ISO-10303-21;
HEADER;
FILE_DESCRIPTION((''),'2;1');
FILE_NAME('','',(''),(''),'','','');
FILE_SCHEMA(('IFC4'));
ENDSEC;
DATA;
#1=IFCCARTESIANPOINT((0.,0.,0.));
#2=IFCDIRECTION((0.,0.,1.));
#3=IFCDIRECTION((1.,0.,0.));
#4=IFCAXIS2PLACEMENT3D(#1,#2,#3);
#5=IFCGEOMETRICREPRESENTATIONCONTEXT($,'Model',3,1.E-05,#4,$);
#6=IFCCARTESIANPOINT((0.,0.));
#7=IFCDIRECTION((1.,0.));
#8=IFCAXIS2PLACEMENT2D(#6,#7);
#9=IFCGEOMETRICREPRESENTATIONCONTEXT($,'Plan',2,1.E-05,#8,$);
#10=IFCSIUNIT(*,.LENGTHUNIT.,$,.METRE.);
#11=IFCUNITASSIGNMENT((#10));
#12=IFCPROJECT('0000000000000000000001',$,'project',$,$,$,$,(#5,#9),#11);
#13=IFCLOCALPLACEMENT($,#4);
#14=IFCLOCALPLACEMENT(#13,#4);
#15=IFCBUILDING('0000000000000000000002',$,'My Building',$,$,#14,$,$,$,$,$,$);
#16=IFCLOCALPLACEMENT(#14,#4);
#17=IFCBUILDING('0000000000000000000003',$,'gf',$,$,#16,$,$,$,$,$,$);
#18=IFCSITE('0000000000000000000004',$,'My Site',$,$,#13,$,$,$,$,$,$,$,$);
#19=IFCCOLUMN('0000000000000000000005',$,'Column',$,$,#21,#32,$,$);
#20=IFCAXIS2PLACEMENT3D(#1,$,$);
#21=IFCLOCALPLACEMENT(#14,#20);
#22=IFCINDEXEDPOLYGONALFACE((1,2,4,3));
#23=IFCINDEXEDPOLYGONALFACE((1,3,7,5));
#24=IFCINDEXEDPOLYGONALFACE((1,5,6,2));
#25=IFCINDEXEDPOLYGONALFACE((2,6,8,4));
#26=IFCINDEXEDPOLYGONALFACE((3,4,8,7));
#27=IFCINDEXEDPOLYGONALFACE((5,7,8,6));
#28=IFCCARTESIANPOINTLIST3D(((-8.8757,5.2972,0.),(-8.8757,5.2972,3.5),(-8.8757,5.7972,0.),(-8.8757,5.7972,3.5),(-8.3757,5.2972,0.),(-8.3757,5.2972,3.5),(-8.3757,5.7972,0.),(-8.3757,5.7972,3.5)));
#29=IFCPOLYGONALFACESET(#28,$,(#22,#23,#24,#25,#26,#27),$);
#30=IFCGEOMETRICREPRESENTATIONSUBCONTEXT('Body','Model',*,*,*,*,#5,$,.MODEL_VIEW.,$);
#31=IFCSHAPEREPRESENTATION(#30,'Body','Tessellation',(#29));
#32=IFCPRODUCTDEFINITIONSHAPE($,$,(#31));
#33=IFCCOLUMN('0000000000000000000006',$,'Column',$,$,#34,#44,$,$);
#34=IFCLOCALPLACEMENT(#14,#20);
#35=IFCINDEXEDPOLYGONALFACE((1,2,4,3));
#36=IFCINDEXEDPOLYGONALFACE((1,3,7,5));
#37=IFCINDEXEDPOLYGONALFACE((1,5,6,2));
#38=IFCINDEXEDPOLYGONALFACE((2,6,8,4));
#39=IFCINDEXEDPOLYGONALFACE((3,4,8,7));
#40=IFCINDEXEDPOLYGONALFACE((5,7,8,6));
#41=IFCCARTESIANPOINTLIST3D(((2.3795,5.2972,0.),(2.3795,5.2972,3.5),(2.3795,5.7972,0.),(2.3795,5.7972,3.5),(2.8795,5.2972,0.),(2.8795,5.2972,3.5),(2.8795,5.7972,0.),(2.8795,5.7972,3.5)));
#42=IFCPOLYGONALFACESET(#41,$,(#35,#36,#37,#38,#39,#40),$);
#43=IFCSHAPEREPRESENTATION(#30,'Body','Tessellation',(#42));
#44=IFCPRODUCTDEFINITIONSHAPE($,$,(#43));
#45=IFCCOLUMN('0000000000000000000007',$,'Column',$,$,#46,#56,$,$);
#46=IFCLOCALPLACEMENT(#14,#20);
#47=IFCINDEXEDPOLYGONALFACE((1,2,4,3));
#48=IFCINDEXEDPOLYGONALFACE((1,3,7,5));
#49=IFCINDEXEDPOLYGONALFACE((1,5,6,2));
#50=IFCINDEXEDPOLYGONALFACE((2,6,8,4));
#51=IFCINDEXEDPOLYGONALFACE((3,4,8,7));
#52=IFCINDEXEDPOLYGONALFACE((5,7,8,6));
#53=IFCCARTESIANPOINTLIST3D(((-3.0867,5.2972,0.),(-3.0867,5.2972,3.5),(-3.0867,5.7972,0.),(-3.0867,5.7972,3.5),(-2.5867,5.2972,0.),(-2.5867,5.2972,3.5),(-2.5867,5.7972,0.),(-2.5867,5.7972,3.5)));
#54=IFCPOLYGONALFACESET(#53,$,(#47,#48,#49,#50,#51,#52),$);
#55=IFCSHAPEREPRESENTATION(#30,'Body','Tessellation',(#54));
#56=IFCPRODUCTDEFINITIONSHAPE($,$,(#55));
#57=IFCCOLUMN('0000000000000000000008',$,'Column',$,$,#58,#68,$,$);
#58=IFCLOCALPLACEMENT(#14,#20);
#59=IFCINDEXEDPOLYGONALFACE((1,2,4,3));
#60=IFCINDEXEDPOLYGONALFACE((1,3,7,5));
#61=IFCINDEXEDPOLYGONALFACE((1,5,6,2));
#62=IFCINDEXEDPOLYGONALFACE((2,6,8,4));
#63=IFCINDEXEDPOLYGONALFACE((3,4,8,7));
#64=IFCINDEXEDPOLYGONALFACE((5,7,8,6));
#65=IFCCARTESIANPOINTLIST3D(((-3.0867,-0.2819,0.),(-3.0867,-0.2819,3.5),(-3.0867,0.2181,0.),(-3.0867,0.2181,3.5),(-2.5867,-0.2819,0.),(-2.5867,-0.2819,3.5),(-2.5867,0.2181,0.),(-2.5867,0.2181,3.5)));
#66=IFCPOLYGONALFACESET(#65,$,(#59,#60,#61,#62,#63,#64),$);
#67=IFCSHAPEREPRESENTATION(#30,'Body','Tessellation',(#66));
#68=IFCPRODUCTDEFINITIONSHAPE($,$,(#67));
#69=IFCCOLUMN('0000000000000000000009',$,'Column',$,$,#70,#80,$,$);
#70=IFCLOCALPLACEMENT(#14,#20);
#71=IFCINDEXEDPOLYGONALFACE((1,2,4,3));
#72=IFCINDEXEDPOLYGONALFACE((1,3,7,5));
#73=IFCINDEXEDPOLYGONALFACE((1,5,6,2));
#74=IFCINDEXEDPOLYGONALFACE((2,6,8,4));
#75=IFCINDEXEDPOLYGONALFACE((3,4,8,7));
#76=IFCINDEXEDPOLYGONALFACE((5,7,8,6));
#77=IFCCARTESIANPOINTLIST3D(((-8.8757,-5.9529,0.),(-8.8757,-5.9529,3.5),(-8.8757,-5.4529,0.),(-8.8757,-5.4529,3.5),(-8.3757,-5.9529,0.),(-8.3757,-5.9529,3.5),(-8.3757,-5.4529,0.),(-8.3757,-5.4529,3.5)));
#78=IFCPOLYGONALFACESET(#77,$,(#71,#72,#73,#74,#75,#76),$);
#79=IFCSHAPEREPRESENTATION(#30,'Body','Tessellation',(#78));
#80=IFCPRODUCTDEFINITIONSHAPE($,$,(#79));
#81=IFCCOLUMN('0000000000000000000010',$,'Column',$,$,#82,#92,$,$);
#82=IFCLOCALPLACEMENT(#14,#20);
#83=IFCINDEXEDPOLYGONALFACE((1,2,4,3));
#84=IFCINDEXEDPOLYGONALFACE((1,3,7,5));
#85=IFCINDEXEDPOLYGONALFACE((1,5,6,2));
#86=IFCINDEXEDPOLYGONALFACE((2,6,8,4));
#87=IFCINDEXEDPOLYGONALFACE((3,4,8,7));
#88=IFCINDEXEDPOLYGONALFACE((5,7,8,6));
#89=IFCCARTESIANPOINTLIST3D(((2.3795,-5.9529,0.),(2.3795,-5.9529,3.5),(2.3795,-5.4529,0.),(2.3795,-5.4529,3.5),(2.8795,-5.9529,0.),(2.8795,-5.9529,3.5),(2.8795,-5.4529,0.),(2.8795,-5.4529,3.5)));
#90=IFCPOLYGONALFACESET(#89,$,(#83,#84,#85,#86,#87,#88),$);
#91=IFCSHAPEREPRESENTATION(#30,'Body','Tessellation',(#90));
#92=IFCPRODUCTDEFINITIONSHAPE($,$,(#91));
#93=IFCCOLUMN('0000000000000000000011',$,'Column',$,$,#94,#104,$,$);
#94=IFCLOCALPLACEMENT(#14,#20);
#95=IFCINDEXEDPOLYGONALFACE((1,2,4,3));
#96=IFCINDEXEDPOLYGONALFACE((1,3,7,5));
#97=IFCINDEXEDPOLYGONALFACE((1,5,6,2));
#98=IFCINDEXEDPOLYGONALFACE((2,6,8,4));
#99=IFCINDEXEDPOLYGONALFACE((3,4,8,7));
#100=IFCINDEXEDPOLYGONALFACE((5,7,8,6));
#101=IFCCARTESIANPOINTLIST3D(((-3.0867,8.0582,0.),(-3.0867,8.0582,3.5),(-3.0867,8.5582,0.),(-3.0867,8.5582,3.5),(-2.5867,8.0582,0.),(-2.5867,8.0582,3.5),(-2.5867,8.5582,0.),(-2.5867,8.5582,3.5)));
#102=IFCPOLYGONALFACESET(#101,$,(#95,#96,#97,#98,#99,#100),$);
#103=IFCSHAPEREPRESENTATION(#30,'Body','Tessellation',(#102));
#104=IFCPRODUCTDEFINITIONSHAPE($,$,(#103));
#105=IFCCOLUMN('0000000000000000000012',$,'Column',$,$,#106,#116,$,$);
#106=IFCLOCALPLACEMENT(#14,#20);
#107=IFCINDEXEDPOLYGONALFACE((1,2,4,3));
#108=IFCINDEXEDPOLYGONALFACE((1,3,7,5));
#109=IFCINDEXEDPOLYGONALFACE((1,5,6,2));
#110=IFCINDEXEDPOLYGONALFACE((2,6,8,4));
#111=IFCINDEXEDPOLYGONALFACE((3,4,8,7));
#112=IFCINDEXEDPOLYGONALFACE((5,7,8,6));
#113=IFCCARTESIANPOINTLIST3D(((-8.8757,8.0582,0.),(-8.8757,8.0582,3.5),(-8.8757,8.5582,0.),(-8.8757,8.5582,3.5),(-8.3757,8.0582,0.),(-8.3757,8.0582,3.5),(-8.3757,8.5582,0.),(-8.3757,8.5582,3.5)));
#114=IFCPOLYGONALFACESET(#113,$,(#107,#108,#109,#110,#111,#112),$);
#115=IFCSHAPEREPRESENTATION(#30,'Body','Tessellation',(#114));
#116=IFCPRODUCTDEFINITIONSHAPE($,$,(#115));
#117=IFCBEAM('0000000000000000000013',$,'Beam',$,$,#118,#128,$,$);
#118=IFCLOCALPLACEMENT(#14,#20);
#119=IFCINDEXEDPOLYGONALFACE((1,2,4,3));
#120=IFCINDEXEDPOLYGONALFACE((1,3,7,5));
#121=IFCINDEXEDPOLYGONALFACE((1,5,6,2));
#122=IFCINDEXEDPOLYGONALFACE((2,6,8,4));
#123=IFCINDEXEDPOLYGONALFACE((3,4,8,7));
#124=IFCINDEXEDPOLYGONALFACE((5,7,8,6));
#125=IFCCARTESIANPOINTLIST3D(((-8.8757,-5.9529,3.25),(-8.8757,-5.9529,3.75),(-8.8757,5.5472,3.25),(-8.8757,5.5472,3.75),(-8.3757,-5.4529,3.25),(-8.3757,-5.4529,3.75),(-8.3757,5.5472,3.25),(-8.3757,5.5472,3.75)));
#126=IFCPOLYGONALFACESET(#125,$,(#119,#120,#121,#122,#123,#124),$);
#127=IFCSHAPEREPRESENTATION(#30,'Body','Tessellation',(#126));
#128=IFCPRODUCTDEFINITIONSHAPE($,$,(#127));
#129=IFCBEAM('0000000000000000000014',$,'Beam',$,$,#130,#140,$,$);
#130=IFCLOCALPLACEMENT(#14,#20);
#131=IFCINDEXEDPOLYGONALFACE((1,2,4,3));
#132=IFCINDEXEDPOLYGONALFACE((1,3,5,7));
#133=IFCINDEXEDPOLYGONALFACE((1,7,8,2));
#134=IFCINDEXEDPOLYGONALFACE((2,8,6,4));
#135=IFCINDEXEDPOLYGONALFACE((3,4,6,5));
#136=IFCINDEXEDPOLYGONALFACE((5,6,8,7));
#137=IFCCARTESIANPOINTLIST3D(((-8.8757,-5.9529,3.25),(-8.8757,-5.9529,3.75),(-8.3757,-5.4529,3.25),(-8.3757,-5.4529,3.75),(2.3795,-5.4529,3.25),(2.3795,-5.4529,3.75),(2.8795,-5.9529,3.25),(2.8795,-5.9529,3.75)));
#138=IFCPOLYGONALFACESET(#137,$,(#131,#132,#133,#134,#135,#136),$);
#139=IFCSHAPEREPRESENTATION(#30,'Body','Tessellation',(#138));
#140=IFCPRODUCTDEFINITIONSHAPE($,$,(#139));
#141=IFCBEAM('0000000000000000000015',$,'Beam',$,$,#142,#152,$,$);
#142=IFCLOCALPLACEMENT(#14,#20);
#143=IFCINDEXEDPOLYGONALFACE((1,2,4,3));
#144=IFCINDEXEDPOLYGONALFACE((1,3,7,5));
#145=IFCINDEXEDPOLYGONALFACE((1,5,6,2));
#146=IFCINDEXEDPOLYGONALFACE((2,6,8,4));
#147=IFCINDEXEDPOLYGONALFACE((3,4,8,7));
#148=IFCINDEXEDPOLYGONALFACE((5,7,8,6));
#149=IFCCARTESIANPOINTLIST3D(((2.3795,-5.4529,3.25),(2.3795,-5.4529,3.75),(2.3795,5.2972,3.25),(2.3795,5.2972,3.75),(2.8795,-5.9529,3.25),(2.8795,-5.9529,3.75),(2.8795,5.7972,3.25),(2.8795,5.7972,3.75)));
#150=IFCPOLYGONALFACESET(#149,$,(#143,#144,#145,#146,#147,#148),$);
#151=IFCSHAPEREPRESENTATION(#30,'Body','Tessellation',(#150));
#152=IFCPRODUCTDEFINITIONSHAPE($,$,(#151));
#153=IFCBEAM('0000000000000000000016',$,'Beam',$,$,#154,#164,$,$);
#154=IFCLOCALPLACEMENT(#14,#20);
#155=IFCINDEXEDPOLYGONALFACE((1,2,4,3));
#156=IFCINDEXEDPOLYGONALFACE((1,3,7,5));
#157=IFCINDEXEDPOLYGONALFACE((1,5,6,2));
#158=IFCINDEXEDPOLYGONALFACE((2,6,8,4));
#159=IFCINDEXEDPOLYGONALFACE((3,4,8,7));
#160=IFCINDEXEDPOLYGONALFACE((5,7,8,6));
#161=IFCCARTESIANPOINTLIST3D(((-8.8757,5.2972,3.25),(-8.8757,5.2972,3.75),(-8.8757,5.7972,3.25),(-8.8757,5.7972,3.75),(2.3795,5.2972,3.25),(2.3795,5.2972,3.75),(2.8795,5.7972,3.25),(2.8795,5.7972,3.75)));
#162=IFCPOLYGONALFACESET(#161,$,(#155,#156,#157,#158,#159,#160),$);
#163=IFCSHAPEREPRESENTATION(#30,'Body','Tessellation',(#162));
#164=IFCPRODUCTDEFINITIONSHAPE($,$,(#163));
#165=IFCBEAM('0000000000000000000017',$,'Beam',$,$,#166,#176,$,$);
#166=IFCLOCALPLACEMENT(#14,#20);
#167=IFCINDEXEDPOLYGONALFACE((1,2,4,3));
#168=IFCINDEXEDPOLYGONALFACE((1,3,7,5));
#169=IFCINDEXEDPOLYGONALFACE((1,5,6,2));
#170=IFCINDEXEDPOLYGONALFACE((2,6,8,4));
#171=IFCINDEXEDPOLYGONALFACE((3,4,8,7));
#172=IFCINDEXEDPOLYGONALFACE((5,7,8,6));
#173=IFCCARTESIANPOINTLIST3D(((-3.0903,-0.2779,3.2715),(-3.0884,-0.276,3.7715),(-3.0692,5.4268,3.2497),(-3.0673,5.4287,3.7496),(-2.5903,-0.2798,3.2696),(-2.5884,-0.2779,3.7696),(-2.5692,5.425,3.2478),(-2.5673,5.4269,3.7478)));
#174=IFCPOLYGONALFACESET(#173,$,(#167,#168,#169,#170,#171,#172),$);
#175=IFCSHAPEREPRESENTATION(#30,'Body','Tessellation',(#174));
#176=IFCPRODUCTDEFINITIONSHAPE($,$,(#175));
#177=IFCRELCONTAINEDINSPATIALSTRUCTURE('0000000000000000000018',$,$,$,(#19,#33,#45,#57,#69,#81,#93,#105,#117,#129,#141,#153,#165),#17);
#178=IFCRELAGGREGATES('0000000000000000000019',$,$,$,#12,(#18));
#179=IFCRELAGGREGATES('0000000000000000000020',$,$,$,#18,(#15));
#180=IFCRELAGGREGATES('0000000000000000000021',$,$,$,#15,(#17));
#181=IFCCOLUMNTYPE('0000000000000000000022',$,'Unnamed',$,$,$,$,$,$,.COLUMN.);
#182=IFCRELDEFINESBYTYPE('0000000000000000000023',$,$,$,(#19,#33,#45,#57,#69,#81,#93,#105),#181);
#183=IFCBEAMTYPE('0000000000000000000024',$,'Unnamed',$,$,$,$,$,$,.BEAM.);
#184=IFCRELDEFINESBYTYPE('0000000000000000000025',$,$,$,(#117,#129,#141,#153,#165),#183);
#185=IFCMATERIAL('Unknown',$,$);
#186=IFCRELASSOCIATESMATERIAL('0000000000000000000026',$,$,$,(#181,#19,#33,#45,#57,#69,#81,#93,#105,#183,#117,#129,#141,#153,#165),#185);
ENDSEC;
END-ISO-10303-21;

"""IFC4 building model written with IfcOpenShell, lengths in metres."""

from ifc_helpers import new_model, si_unit, frame, origin_with_axes, origin_2d_with_axis, place, context, subcontext, project, spatial, rectangle, extrude, clip, halfspace, material, material_profile, profile_set, profile_usage, type_object, element, save


model = new_model("IFC4")

# Units and contexts
model_context = context("Model", 3, precision=1e-05, world=origin_with_axes())
plan_context = context("Plan", 2, precision=1e-05, world=origin_2d_with_axis())
body_context_1 = subcontext(model_context, "Body", "Model", "MODEL_VIEW")
ifc_project = project(units=[si_unit("LENGTHUNIT", "METRE")], contexts=[model_context, plan_context])

# Site, buildings
site_placement = place(None, origin_with_axes())
site = spatial("IfcSite", under=ifc_project, at=site_placement, Name="My Site")
building_1_placement = place(site_placement, origin_with_axes())
building_1 = spatial("IfcBuilding", under=site, at=building_1_placement, Name="My Building")
building_2_placement = place(building_1_placement, origin_with_axes())
building_2 = spatial("IfcBuilding", under=building_1, at=building_2_placement, Name="gf")

# Columns
ifc_material = material(Name="Unknown")
ifc_material_profile_1 = material_profile(ifc_material, rectangle(XDim=0.5, YDim=0.5))
ifc_profile_set_1 = profile_set([ifc_material_profile_1])
ifc_profile_usage_1 = profile_usage(ifc_profile_set_1, cardinal=5)
column_type = type_object("IfcColumnType", Name="Unnamed", PredefinedType="COLUMN", material=ifc_profile_set_1)
column_1_placement = place(building_2_placement, frame((-8.6257, 5.5472, 0.0), z_axis=(0.0, 0.0, 1.0), x_axis=(1.0, 0.0, 0.0)))
element("IfcColumn", 1, at=column_1_placement, inside=building_2, type_object=column_type, material=ifc_profile_usage_1, Name="Column", context=body_context_1, shape_type="SweptSolid", body=[
    extrude(rectangle(XDim=0.5, YDim=0.5), origin_with_axes(), (0.0, 0.0, 1.0), 3.5),
])
ifc_profile_usage_2 = profile_usage(ifc_profile_set_1, cardinal=5)
column_2_placement = place(building_2_placement, frame((2.6295, 5.5472, 0.0), z_axis=(0.0, 0.0, 1.0), x_axis=(1.0, 0.0, 0.0)))
element("IfcColumn", 2, at=column_2_placement, inside=building_2, type_object=column_type, material=ifc_profile_usage_2, Name="Column", context=body_context_1, shape_type="SweptSolid", body=[
    extrude(rectangle(XDim=0.5, YDim=0.5), origin_with_axes(), (0.0, 0.0, 1.0), 3.5),
])
ifc_profile_usage_3 = profile_usage(ifc_profile_set_1, cardinal=5)
column_3_placement = place(building_2_placement, frame((-2.8367, 5.5472, 0.0), z_axis=(0.0, 0.0, 1.0), x_axis=(1.0, 0.0, 0.0)))
element("IfcColumn", 3, at=column_3_placement, inside=building_2, type_object=column_type, material=ifc_profile_usage_3, Name="Column", context=body_context_1, shape_type="SweptSolid", body=[
    extrude(rectangle(XDim=0.5, YDim=0.5), origin_with_axes(), (0.0, 0.0, 1.0), 3.5),
])
ifc_profile_usage_4 = profile_usage(ifc_profile_set_1, cardinal=5)
column_4_placement = place(building_2_placement, frame((-2.8367, -0.0319, 0.0), z_axis=(0.0, 0.0, 1.0), x_axis=(1.0, 0.0, 0.0)))
element("IfcColumn", 4, at=column_4_placement, inside=building_2, type_object=column_type, material=ifc_profile_usage_4, Name="Column", context=body_context_1, shape_type="SweptSolid", body=[
    extrude(rectangle(XDim=0.5, YDim=0.5), origin_with_axes(), (0.0, 0.0, 1.0), 3.5),
])
ifc_profile_usage_5 = profile_usage(ifc_profile_set_1, cardinal=5)
column_5_placement = place(building_2_placement, frame((-8.6257, -5.7029, 0.0), z_axis=(0.0, 0.0, 1.0), x_axis=(1.0, 0.0, 0.0)))
element("IfcColumn", 5, at=column_5_placement, inside=building_2, type_object=column_type, material=ifc_profile_usage_5, Name="Column", context=body_context_1, shape_type="SweptSolid", body=[
    extrude(rectangle(XDim=0.5, YDim=0.5), origin_with_axes(), (0.0, 0.0, 1.0), 3.5),
])
ifc_profile_usage_6 = profile_usage(ifc_profile_set_1, cardinal=5)
column_6_placement = place(building_2_placement, frame((2.6295, -5.7029, 0.0), z_axis=(0.0, 0.0, 1.0), x_axis=(1.0, 0.0, 0.0)))
element("IfcColumn", 6, at=column_6_placement, inside=building_2, type_object=column_type, material=ifc_profile_usage_6, Name="Column", context=body_context_1, shape_type="SweptSolid", body=[
    extrude(rectangle(XDim=0.5, YDim=0.5), origin_with_axes(), (0.0, 0.0, 1.0), 3.5),
])
ifc_profile_usage_7 = profile_usage(ifc_profile_set_1, cardinal=5)
column_7_placement = place(building_2_placement, frame((-2.8367, 8.3082, 0.0), z_axis=(0.0, 0.0, 1.0), x_axis=(1.0, 0.0, 0.0)))
element("IfcColumn", 7, at=column_7_placement, inside=building_2, type_object=column_type, material=ifc_profile_usage_7, Name="Column", context=body_context_1, shape_type="SweptSolid", body=[
    extrude(rectangle(XDim=0.5, YDim=0.5), origin_with_axes(), (0.0, 0.0, 1.0), 3.5),
])
ifc_profile_usage_8 = profile_usage(ifc_profile_set_1, cardinal=5)
column_8_placement = place(building_2_placement, frame((-8.6257, 8.3082, 0.0), z_axis=(0.0, 0.0, 1.0), x_axis=(1.0, 0.0, 0.0)))
element("IfcColumn", 8, at=column_8_placement, inside=building_2, type_object=column_type, material=ifc_profile_usage_8, Name="Column", context=body_context_1, shape_type="SweptSolid", body=[
    extrude(rectangle(XDim=0.5, YDim=0.5), origin_with_axes(), (0.0, 0.0, 1.0), 3.5),
])

# Beams
ifc_material_profile_2 = material_profile(ifc_material, rectangle(XDim=0.5, YDim=0.5))
ifc_profile_set_2 = profile_set([ifc_material_profile_2])
ifc_profile_usage_9 = profile_usage(ifc_profile_set_2, cardinal=5)
beam_type = type_object("IfcBeamType", Name="Unnamed", PredefinedType="BEAM", material=ifc_profile_set_2)
beam_1_placement = place(building_2_placement, frame((-8.6257, 5.5472, 3.5), z_axis=(0.0, -1.0, 0.0), x_axis=(1.0, 0.0, 0.0)))
element("IfcBeam", 9, at=beam_1_placement, inside=building_2, type_object=beam_type, material=ifc_profile_usage_9, Name="Beam", context=body_context_1, shape_type="Clipping", body=[
    clip(extrude(rectangle(XDim=0.5, YDim=0.5), origin_with_axes(), (0.0, 0.0, 1.0), 11.5002), halfspace(frame((-0.25, -3.5, 11.5002), z_axis=(0.707106, 0.0, 0.707107), x_axis=(0.0, -1.0, 0.0)), False)),
])
ifc_profile_usage_10 = profile_usage(ifc_profile_set_2, cardinal=5)
beam_2_placement = place(building_2_placement, frame((-8.8757, -5.7029, 3.5), z_axis=(1.0, -0.000001, 0.000001), x_axis=(0.000001, 1.0, 0.0)))
element("IfcBeam", 10, at=beam_2_placement, inside=building_2, type_object=beam_type, material=ifc_profile_usage_10, Name="Beam", context=body_context_1, shape_type="Clipping", body=[
    clip(clip(extrude(rectangle(XDim=0.5, YDim=0.5), origin_with_axes(), (0.0, 0.0, 1.0), 11.7552), halfspace(frame((-0.25, -3.5, 11.7552), z_axis=(0.707107, 0.0, 0.707107), x_axis=(0.0, -1.0, 0.0)), False)), halfspace(frame((-0.25, -3.5, 0.0), z_axis=(0.707107, 0.0, -0.707107), x_axis=(0.000001, -1.0, 0.0)), False)),
])
ifc_profile_usage_11 = profile_usage(ifc_profile_set_2, cardinal=5)
beam_3_placement = place(building_2_placement, frame((2.6295, -5.9529, 3.5), z_axis=(0.0, 1.0, 0.0), x_axis=(-1.0, 0.0, 0.0)))
element("IfcBeam", 11, at=beam_3_placement, inside=building_2, type_object=beam_type, material=ifc_profile_usage_11, Name="Beam", context=body_context_1, shape_type="Clipping", body=[
    clip(clip(extrude(rectangle(XDim=0.5, YDim=0.5), origin_with_axes(), (0.0, 0.0, 1.0), 11.7502), halfspace(frame((-0.25, -3.5, 11.7502), z_axis=(0.707107, 0.0, 0.707107), x_axis=(-0.000001, -1.0, 0.0)), False)), halfspace(frame((-0.25, -3.5, 0.0), z_axis=(0.707107, 0.0, -0.707106), x_axis=(0.0, -1.0, 0.0)), False)),
])
ifc_profile_usage_12 = profile_usage(ifc_profile_set_2, cardinal=5)
beam_4_placement = place(building_2_placement, frame((2.8795, 5.5472, 3.5), z_axis=(-1.0, -0.000001, 0.000001), x_axis=(0.000001, -1.0, 0.0)))
element("IfcBeam", 12, at=beam_4_placement, inside=building_2, type_object=beam_type, material=ifc_profile_usage_12, Name="Beam", context=body_context_1, shape_type="Clipping", body=[
    clip(extrude(rectangle(XDim=0.5, YDim=0.5), origin_with_axes(), (0.0, 0.0, 1.0), 11.7552), halfspace(frame((-0.25, -3.5, 0.0), z_axis=(0.707107, 0.0, -0.707106), x_axis=(0.000001, -1.0, 0.0)), False)),
])
ifc_profile_usage_13 = profile_usage(ifc_profile_set_2, cardinal=5)
beam_5_placement = place(building_2_placement, frame((-2.8183, 5.4268, 3.4987), z_axis=(-0.003695, -0.999986, 0.003827), x_axis=(0.999986, -0.003709, -0.003708)))
element("IfcBeam", 13, at=beam_5_placement, inside=building_2, type_object=beam_type, material=ifc_profile_usage_13, Name="Beam", context=body_context_1, shape_type="SweptSolid", body=[
    extrude(rectangle(XDim=0.5, YDim=0.5), origin_with_axes(), (0.0, 0.0, 1.0), 5.7048),
])

save(model, "model.ifc")
